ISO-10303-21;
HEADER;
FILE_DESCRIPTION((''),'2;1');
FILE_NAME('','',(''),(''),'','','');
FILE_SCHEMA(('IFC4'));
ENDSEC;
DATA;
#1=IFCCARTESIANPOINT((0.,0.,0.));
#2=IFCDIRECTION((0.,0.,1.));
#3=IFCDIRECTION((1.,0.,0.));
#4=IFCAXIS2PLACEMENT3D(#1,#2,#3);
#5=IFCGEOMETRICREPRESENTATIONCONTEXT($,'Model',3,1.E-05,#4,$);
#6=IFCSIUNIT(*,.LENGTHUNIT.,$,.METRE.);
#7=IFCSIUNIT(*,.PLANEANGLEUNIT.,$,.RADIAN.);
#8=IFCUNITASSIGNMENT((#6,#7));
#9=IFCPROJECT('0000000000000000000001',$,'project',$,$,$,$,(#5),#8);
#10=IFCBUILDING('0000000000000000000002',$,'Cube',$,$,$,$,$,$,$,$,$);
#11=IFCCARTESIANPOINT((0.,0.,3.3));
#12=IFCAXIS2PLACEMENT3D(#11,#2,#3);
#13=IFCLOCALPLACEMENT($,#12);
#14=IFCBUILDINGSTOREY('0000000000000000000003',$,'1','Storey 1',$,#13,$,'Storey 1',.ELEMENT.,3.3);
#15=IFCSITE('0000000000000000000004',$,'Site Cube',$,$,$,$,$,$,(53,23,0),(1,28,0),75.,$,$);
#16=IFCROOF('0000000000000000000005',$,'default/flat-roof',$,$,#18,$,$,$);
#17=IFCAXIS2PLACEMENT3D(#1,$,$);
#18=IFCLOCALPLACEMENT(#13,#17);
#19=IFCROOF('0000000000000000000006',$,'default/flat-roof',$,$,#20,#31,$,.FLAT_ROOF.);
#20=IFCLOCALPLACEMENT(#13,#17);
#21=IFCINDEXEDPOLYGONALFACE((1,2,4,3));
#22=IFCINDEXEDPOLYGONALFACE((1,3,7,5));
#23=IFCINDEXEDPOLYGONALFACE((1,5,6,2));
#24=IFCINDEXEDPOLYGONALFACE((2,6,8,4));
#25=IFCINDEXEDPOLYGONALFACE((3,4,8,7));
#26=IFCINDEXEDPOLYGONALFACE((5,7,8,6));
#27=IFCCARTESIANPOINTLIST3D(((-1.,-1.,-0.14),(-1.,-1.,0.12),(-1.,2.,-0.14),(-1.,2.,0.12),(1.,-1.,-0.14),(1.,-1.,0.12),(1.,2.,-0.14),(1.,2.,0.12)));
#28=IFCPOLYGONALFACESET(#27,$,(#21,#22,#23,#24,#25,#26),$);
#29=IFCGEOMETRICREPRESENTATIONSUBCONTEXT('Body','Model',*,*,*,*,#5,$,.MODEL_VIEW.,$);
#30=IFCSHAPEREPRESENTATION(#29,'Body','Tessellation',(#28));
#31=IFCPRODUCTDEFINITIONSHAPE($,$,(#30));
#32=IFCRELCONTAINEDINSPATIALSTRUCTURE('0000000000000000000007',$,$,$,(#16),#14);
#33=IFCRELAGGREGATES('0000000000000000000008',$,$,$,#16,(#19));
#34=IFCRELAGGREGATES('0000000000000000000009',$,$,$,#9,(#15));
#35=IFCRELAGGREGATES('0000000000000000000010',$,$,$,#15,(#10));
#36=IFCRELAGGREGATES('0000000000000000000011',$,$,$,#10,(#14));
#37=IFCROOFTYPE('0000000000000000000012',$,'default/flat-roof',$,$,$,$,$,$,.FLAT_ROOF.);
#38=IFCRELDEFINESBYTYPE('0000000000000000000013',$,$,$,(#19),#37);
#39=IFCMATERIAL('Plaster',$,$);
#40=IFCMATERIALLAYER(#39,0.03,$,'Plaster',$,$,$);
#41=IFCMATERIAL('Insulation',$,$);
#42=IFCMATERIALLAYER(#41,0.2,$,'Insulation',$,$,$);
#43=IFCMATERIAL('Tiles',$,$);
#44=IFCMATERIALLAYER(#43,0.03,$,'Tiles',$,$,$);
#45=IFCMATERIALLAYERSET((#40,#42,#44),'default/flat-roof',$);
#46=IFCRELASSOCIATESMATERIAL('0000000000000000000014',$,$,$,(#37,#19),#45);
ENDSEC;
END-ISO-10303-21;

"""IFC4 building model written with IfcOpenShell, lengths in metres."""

from ifc_helpers import new_model, si_unit, frame, origin, origin_with_axes, place, context, subcontext, project, spatial, polyline, outline, extrude, material, layer, layer_set, layer_usage, type_object, element, aggregate, save


model = new_model("IFC4")

# Units and contexts
model_context = context("Model", 3, precision=1e-05, world=origin_with_axes())
body_context = subcontext(model_context, "Body", "Model", "MODEL_VIEW")
ifc_project = project(units=[si_unit("LENGTHUNIT", "METRE"), si_unit("PLANEANGLEUNIT", "RADIAN")], contexts=[model_context])

# Site, building, storey
site = spatial("IfcSite", under=ifc_project, Name="Site Cube", RefLatitude=(53, 23, 0), RefLongitude=(1, 28, 0), RefElevation=75.0)
building = spatial("IfcBuilding", under=site, Name="Cube")
storey_placement = place(None, frame((0.0, 0.0, 3.3), z_axis=(0.0, 0.0, 1.0), x_axis=(1.0, 0.0, 0.0)))
storey = spatial("IfcBuildingStorey", under=building, at=storey_placement, Name="1", Description="Storey 1", LongName="Storey 1", CompositionType="ELEMENT", Elevation=3.3)

# Roofs
roof_1_placement = place(storey_placement, frame((0.0, 0.0, -3.3), z_axis=(0.0, 0.0, 1.0), x_axis=(1.0, 0.0, 0.0)))
roof_1 = element("IfcRoof", 1, at=roof_1_placement, inside=storey, Name="default/flat-roof")
ifc_material_1 = material(Name="Plaster")
ifc_layer_1 = layer(ifc_material_1, 0.03, Name="Plaster")
ifc_material_2 = material(Name="Insulation")
ifc_layer_2 = layer(ifc_material_2, 0.2, Name="Insulation")
ifc_material_3 = material(Name="Tiles")
ifc_layer_3 = layer(ifc_material_3, 0.03, Name="Tiles")
ifc_layer_set = layer_set([ifc_layer_1, ifc_layer_2, ifc_layer_3], Name="default/flat-roof")
ifc_layer_usage = layer_usage(ifc_layer_set, "AXIS3", "POSITIVE", 0.0)
roof_type = type_object("IfcRoofType", Name="default/flat-roof", PredefinedType="FLAT_ROOF", material=ifc_layer_set)
roof_2_placement = place(roof_1_placement, frame((1.0, 2.0, 3.16), z_axis=(0.0, 0.0, 1.0), x_axis=(0.0, 1.0, 0.0)))
roof_2 = element("IfcRoof", 2, at=roof_2_placement, type_object=roof_type, material=ifc_layer_usage, Name="default/flat-roof", PredefinedType="FLAT_ROOF", context=body_context, shape_type="SweptSolid", body=[
    extrude(outline(polyline([(0.0, 0.0), (0.0, 2.0), (-3.0, 2.0), (-3.0, 0.0), (0.0, 0.0)])), origin(), (0.0, 0.0, 1.0), 0.26),
])
aggregate(roof_1, [roof_2])

save(model, "model.ifc")
